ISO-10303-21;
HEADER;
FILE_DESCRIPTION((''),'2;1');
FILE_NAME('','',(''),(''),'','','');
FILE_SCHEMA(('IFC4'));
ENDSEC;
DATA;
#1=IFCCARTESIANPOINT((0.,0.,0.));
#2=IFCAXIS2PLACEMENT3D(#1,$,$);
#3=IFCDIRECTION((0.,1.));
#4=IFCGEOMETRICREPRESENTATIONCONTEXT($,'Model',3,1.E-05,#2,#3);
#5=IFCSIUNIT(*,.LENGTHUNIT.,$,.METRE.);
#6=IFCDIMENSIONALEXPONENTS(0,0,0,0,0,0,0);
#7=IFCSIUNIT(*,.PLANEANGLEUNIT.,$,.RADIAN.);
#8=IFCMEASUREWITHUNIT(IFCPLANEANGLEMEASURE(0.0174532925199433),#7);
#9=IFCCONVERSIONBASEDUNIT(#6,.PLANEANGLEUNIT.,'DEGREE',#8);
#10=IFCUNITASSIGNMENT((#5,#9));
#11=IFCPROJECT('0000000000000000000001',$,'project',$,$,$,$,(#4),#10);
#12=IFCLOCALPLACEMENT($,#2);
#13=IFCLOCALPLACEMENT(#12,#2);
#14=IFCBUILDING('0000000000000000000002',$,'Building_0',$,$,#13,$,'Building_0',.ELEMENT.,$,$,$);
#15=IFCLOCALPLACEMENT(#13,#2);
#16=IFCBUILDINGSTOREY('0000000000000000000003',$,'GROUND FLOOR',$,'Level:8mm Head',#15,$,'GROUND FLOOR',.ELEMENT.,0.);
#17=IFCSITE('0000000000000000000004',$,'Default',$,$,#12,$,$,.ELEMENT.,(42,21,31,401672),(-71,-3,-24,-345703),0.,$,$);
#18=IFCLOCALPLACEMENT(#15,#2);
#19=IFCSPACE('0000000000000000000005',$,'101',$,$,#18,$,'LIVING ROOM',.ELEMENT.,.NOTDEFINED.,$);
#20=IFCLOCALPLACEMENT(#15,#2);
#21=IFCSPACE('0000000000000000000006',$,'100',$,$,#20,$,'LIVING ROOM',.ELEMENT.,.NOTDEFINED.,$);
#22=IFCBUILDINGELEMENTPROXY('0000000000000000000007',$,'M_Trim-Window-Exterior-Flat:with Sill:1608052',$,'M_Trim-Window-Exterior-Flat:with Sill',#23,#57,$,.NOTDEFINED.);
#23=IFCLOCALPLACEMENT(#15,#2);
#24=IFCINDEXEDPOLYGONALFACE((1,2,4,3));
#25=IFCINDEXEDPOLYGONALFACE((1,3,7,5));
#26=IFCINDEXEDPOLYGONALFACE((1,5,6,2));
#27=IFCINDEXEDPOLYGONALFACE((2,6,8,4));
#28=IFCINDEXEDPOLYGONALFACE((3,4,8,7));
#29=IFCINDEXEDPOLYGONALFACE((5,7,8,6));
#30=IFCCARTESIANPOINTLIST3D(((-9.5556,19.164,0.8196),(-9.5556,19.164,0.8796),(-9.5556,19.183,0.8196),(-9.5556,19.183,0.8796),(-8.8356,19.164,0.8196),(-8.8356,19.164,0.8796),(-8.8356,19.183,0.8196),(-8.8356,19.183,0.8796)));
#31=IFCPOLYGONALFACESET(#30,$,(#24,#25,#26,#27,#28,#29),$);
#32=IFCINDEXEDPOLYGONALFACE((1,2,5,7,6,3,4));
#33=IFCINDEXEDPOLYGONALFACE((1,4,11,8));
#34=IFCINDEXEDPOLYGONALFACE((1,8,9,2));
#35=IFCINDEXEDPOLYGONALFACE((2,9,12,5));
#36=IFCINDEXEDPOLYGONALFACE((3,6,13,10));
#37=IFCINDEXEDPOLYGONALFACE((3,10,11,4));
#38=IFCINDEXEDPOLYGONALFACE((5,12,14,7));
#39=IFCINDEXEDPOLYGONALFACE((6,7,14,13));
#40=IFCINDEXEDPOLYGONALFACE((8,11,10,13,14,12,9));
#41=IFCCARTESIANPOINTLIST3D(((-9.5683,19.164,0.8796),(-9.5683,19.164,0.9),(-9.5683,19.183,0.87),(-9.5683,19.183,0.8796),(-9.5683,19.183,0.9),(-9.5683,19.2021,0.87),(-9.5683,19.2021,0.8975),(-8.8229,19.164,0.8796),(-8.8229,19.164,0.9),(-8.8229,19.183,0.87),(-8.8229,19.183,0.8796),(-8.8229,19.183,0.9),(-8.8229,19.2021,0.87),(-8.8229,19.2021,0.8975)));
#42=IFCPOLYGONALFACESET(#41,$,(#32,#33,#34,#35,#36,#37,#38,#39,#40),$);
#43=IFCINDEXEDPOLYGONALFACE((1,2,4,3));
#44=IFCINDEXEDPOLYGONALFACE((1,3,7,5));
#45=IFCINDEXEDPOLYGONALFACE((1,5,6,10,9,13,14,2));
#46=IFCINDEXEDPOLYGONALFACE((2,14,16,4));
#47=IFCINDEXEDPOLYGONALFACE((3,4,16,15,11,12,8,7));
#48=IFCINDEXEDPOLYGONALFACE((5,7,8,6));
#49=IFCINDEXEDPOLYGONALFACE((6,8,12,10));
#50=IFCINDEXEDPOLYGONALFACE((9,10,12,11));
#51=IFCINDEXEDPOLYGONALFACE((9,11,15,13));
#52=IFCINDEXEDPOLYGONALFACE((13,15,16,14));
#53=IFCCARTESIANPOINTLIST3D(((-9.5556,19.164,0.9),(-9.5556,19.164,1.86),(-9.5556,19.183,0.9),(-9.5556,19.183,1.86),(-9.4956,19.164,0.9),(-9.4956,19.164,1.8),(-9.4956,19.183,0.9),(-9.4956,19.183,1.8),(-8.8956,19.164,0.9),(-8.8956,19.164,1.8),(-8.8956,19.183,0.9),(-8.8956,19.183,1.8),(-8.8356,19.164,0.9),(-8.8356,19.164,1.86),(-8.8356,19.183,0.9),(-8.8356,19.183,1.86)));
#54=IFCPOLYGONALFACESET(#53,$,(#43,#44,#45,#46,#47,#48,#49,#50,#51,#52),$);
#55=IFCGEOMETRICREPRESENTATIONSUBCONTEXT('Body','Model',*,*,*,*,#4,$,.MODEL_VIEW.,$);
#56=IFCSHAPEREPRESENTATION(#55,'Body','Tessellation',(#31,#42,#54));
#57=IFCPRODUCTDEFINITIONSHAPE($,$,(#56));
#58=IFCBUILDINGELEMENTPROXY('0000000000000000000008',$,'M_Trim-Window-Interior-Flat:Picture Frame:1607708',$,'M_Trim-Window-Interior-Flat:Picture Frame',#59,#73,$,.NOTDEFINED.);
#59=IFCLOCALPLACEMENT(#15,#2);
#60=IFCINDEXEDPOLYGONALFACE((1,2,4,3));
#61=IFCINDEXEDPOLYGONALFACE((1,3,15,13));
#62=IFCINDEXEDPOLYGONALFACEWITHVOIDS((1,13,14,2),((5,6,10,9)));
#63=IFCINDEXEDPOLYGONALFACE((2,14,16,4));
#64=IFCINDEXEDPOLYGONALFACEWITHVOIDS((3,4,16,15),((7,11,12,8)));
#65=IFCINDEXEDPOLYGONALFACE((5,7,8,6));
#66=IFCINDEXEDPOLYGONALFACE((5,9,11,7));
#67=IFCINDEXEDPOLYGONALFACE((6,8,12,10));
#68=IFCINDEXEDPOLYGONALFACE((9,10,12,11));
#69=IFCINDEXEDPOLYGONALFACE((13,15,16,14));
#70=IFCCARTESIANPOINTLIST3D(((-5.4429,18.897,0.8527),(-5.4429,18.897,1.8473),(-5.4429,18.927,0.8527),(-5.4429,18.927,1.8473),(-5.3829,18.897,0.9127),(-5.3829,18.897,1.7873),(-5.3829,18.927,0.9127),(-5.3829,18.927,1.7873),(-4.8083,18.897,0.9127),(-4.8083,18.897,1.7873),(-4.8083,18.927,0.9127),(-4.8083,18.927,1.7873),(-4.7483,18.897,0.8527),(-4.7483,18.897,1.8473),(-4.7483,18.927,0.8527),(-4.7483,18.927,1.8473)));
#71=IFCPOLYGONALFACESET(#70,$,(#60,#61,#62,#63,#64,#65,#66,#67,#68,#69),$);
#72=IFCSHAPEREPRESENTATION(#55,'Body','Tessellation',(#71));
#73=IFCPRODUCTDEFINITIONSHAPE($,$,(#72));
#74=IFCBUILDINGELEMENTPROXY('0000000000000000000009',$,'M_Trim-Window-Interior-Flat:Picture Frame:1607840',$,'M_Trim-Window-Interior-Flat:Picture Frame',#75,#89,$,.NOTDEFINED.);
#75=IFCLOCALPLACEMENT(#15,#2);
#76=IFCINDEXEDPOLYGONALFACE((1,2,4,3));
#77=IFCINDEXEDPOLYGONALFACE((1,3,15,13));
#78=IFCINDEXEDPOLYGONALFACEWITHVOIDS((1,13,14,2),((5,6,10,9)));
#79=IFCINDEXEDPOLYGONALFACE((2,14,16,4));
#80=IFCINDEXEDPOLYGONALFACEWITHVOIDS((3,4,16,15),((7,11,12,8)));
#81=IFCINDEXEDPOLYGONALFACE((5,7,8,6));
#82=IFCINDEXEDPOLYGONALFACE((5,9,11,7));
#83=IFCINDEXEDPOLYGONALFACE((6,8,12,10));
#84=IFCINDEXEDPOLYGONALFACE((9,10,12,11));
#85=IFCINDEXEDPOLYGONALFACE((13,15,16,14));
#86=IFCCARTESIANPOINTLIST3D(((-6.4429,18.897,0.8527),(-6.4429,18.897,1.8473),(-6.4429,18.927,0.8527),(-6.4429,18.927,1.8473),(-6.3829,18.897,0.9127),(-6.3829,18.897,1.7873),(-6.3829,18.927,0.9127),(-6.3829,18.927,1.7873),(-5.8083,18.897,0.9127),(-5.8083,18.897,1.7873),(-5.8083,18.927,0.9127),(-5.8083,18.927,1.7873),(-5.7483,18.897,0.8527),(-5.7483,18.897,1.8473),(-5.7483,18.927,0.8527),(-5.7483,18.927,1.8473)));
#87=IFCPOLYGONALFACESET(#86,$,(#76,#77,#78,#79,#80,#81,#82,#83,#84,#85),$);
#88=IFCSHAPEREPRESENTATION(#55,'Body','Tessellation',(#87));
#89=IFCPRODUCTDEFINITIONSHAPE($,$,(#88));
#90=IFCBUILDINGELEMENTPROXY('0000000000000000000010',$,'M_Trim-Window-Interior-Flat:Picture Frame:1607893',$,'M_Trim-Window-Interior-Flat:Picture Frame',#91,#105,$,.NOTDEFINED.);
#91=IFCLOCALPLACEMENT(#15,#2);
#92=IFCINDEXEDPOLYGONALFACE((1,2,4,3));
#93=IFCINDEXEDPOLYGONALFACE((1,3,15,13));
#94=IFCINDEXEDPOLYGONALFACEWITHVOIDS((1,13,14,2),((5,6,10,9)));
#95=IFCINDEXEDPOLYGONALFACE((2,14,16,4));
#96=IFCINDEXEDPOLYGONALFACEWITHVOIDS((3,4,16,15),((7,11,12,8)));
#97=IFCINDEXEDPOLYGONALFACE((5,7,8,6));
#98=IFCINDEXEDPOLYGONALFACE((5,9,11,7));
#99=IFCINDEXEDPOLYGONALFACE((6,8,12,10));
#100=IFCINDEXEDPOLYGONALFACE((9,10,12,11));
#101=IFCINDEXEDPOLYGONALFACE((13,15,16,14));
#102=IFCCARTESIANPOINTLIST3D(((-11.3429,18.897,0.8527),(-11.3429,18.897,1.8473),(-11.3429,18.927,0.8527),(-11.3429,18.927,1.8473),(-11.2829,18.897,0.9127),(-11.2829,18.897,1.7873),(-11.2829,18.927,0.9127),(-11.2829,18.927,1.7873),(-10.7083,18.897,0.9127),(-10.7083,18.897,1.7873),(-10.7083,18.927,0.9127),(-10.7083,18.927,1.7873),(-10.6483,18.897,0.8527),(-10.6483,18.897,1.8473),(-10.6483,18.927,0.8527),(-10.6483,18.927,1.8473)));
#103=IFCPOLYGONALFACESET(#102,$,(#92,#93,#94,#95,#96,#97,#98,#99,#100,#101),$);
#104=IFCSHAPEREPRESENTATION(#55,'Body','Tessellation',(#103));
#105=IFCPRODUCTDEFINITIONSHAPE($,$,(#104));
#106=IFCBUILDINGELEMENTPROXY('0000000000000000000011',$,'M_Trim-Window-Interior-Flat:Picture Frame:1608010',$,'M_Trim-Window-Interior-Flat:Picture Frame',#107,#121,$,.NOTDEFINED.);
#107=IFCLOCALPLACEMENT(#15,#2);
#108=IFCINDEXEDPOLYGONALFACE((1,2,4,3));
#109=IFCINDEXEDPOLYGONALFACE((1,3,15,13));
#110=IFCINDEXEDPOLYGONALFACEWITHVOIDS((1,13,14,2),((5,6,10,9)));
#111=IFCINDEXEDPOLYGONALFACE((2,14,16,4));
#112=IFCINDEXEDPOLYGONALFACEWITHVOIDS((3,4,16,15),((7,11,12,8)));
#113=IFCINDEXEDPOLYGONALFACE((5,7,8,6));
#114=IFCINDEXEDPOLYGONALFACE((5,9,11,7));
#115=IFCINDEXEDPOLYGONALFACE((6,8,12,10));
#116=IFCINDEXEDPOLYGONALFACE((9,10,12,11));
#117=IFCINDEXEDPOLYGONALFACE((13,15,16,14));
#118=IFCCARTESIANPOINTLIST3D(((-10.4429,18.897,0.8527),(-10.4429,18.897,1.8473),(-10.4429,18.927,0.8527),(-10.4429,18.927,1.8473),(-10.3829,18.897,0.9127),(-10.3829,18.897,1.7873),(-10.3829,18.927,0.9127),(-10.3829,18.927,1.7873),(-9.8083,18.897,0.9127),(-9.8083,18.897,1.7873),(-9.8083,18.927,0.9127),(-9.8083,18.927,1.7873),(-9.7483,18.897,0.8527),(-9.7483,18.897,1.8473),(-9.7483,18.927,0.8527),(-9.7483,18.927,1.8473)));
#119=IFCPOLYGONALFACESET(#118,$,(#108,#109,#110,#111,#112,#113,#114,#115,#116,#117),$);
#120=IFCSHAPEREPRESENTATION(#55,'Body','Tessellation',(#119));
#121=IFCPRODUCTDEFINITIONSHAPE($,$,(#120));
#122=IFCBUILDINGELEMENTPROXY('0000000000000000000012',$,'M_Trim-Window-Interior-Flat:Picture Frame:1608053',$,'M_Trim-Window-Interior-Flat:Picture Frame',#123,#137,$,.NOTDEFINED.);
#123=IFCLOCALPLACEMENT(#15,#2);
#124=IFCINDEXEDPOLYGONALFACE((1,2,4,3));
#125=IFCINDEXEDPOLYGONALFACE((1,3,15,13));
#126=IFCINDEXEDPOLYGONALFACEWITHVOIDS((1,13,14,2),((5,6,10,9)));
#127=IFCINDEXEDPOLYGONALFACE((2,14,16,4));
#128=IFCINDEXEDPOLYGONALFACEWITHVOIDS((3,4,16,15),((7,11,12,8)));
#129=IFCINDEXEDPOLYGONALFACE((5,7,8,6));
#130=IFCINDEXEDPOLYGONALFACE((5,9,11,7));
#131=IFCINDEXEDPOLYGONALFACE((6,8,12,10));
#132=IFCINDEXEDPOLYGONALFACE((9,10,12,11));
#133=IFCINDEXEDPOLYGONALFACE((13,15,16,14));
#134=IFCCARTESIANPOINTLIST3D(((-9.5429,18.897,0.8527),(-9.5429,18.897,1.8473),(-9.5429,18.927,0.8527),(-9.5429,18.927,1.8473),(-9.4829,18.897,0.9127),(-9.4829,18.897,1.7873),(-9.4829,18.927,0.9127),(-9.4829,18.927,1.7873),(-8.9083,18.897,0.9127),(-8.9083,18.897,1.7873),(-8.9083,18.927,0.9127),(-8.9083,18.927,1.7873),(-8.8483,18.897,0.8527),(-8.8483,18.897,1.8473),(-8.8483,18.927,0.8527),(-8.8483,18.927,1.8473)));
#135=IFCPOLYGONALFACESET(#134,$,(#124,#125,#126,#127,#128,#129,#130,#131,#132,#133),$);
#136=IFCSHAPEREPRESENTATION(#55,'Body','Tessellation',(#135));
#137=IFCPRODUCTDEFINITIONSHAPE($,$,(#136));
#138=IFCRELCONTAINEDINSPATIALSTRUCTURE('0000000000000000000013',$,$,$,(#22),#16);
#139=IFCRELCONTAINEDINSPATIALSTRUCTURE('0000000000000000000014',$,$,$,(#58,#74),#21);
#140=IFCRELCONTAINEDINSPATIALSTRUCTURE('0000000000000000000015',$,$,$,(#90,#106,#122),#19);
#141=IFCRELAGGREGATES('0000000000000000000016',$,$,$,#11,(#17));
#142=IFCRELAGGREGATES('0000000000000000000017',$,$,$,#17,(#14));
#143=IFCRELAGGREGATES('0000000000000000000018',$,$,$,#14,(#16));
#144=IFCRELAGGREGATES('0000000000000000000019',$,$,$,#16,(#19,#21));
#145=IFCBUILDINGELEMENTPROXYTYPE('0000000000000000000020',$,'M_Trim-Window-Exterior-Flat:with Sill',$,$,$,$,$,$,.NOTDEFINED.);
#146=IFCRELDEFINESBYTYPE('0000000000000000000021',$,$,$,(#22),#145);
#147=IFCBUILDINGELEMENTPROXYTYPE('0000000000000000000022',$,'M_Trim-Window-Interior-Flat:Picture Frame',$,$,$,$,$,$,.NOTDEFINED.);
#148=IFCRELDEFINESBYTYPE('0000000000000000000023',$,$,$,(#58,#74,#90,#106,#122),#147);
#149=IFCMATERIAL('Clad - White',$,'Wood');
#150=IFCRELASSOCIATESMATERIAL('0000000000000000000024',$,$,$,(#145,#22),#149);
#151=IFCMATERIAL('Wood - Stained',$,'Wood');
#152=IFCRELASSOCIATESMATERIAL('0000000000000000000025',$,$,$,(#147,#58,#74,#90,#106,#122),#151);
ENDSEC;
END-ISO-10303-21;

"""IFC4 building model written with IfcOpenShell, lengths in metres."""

from ifc_helpers import new_model, entity, si_unit, converted_unit, direction, frame, origin, place, context, subcontext, project, spatial, indexed_curve, outline, extrude, source, transform, mapped, material, type_object, type_shapes, element, save


model = new_model("IFC4")

# Units and contexts
model_context = context("Model", 3, precision=1e-05, world=origin(), true_north=direction((0.0, 1.0)))
body_context = subcontext(model_context, "Body", "Model", "MODEL_VIEW")
ifc_project = project(units=[si_unit("LENGTHUNIT", "METRE"), converted_unit("PLANEANGLEUNIT", "DEGREE", entity("IfcPlaneAngleMeasure", 0.0174532925199433), si_unit("PLANEANGLEUNIT", "RADIAN"), dimensions=[0, 0, 0, 0, 0, 0, 0])], contexts=[model_context])

# Site, building, storey
site_placement = place(None, origin())
site = spatial("IfcSite", under=ifc_project, at=site_placement, Name="Default", CompositionType="ELEMENT", RefLatitude=(42, 21, 31, 401672), RefLongitude=(-71, -3, -24, -345703), RefElevation=0.0)
building_placement = place(site_placement, origin())
building = spatial("IfcBuilding", under=site, at=building_placement, Name="Building_0", LongName="Building_0", CompositionType="ELEMENT")
storey_placement = place(building_placement, origin())
storey = spatial("IfcBuildingStorey", under=building, at=storey_placement, Name="GROUND FLOOR", ObjectType="Level:8mm Head", LongName="GROUND FLOOR", CompositionType="ELEMENT", Elevation=0.0)

# Shared definitions
space_1_placement = place(storey_placement, origin())
space_1 = spatial("IfcSpace", under=storey, at=space_1_placement, Name="101", LongName="LIVING ROOM", CompositionType="ELEMENT", PredefinedType="NOTDEFINED")

# Shared definitions
ifc_material_1 = material(Name="Clad - White", Category="Wood")

# Shared definitions
space_2_placement = place(storey_placement, origin())
space_2 = spatial("IfcSpace", under=storey, at=space_2_placement, Name="100", LongName="LIVING ROOM", CompositionType="ELEMENT", PredefinedType="NOTDEFINED")

# Building element proxies
ifc_material_2 = material(Name="Wood - Stained", Category="Wood")
building_element_proxy_type_1 = type_object("IfcBuildingElementProxyType", Name="M_Trim-Window-Exterior-Flat:with Sill", PredefinedType="NOTDEFINED", material=ifc_material_1)
shared_shape_1 = source(origin(), body_context, "Body", "SweptSolid", [
    extrude(outline(indexed_curve([(-0.36, -0.03), (0.36, -0.03), (0.36, 0.03), (-0.36, 0.03), (-0.36, -0.03)], self_intersect=False)), frame((0.0, -0.9504, 0.0), z_axis=(0.0, 0.0, 1.0), x_axis=(-1.0, 0.0, 0.0)), (0.0, 0.0, 1.0), 0.0191),
    extrude(outline(indexed_curve([(-0.019, -0.0152), (0.0, -0.0152), (0.0, -0.0057), (0.019, -0.0057), (0.019, 0.0148), (0.0, 0.0148), (-0.019, 0.0123), (-0.019, -0.0152)], self_intersect=False)), frame((-0.3727, -0.9148, 0.019), z_axis=(1.0, 0.0, 0.0), x_axis=(0.0, 0.0, -1.0)), (0.0, 0.0, 1.0), 0.7454),
    extrude(outline(indexed_curve([(-0.495, -0.36), (0.465, -0.36), (0.465, -0.3), (-0.435, -0.3), (-0.435, 0.3), (0.465, 0.3), (0.465, 0.36), (-0.495, 0.36), (-0.495, -0.36)], self_intersect=False)), frame((0.0, -0.435, 0.0), z_axis=(0.0, 0.0, 1.0), x_axis=(0.0, -1.0, 0.0)), (0.0, 0.0, 1.0), 0.0191),
])
type_shapes(building_element_proxy_type_1, [shared_shape_1])
for number, where, z_axis, x_axis, name in (
    (1, (-9.1956, 19.164, 1.8), (0.0, 1.0, 0.0), (-1.0, 0.0, 0.0), "M_Trim-Window-Exterior-Flat:with Sill:1608052"),
):
    element("IfcBuildingElementProxy", number, at=place(storey_placement, frame(where, z_axis=z_axis, x_axis=x_axis)), inside=storey, type_object=building_element_proxy_type_1, material=ifc_material_1, Name=name, ObjectType="M_Trim-Window-Exterior-Flat:with Sill", PredefinedType="NOTDEFINED", context=body_context, shape_type="MappedRepresentation", body=[
        mapped(shared_shape_1, transform((0.0, 0.0, 0.0), scale=1.0)),
    ])
building_element_proxy_type_2 = type_object("IfcBuildingElementProxyType", Name="M_Trim-Window-Interior-Flat:Picture Frame", PredefinedType="NOTDEFINED", material=ifc_material_2)
shared_shape_2 = source(origin(), body_context, "Body", "SweptSolid", [
    extrude(outline(indexed_curve([(-0.3473, -0.4973), (0.3473, -0.4973), (0.3473, 0.4973), (-0.3473, 0.4973), (-0.3473, -0.4973)], self_intersect=False), holes=[indexed_curve([(-0.2873, -0.4373), (-0.2873, 0.4373), (0.2873, 0.4373), (0.2873, -0.4373), (-0.2873, -0.4373)], self_intersect=False)]), frame((0.0, -0.45, 0.0), z_axis=(0.0, 0.0, 1.0), x_axis=(-1.0, 0.0, 0.0)), (0.0, 0.0, 1.0), 0.03),
])
type_shapes(building_element_proxy_type_2, [shared_shape_2])
for number, where, z_axis, x_axis, name in (
    (2, (-5.0956, 18.927, 1.8), (0.0, -1.0, 0.0), (1.0, 0.0, 0.0), "M_Trim-Window-Interior-Flat:Picture Frame:1607708"),
    (3, (-6.0956, 18.927, 1.8), (0.0, -1.0, 0.0), (1.0, 0.0, 0.0), "M_Trim-Window-Interior-Flat:Picture Frame:1607840"),
):
    element("IfcBuildingElementProxy", number, at=place(space_2_placement, frame(where, z_axis=z_axis, x_axis=x_axis)), inside=space_2, type_object=building_element_proxy_type_2, material=ifc_material_2, Name=name, ObjectType="M_Trim-Window-Interior-Flat:Picture Frame", PredefinedType="NOTDEFINED", context=body_context, shape_type="MappedRepresentation", body=[
        mapped(shared_shape_2, transform((0.0, 0.0, 0.0), scale=1.0)),
    ])
for number, where, z_axis, x_axis, name in (
    (4, (-10.9956, 18.927, 1.8), (0.0, -1.0, 0.0), (1.0, 0.0, 0.0), "M_Trim-Window-Interior-Flat:Picture Frame:1607893"),
    (5, (-10.0956, 18.927, 1.8), (0.0, -1.0, 0.0), (1.0, 0.0, 0.0), "M_Trim-Window-Interior-Flat:Picture Frame:1608010"),
    (6, (-9.1956, 18.927, 1.8), (0.0, -1.0, 0.0), (1.0, 0.0, 0.0), "M_Trim-Window-Interior-Flat:Picture Frame:1608053"),
):
    element("IfcBuildingElementProxy", number, at=place(space_1_placement, frame(where, z_axis=z_axis, x_axis=x_axis)), inside=space_1, type_object=building_element_proxy_type_2, material=ifc_material_2, Name=name, ObjectType="M_Trim-Window-Interior-Flat:Picture Frame", PredefinedType="NOTDEFINED", context=body_context, shape_type="MappedRepresentation", body=[
        mapped(shared_shape_2, transform((0.0, 0.0, 0.0), scale=1.0)),
    ])

save(model, "model.ifc")
